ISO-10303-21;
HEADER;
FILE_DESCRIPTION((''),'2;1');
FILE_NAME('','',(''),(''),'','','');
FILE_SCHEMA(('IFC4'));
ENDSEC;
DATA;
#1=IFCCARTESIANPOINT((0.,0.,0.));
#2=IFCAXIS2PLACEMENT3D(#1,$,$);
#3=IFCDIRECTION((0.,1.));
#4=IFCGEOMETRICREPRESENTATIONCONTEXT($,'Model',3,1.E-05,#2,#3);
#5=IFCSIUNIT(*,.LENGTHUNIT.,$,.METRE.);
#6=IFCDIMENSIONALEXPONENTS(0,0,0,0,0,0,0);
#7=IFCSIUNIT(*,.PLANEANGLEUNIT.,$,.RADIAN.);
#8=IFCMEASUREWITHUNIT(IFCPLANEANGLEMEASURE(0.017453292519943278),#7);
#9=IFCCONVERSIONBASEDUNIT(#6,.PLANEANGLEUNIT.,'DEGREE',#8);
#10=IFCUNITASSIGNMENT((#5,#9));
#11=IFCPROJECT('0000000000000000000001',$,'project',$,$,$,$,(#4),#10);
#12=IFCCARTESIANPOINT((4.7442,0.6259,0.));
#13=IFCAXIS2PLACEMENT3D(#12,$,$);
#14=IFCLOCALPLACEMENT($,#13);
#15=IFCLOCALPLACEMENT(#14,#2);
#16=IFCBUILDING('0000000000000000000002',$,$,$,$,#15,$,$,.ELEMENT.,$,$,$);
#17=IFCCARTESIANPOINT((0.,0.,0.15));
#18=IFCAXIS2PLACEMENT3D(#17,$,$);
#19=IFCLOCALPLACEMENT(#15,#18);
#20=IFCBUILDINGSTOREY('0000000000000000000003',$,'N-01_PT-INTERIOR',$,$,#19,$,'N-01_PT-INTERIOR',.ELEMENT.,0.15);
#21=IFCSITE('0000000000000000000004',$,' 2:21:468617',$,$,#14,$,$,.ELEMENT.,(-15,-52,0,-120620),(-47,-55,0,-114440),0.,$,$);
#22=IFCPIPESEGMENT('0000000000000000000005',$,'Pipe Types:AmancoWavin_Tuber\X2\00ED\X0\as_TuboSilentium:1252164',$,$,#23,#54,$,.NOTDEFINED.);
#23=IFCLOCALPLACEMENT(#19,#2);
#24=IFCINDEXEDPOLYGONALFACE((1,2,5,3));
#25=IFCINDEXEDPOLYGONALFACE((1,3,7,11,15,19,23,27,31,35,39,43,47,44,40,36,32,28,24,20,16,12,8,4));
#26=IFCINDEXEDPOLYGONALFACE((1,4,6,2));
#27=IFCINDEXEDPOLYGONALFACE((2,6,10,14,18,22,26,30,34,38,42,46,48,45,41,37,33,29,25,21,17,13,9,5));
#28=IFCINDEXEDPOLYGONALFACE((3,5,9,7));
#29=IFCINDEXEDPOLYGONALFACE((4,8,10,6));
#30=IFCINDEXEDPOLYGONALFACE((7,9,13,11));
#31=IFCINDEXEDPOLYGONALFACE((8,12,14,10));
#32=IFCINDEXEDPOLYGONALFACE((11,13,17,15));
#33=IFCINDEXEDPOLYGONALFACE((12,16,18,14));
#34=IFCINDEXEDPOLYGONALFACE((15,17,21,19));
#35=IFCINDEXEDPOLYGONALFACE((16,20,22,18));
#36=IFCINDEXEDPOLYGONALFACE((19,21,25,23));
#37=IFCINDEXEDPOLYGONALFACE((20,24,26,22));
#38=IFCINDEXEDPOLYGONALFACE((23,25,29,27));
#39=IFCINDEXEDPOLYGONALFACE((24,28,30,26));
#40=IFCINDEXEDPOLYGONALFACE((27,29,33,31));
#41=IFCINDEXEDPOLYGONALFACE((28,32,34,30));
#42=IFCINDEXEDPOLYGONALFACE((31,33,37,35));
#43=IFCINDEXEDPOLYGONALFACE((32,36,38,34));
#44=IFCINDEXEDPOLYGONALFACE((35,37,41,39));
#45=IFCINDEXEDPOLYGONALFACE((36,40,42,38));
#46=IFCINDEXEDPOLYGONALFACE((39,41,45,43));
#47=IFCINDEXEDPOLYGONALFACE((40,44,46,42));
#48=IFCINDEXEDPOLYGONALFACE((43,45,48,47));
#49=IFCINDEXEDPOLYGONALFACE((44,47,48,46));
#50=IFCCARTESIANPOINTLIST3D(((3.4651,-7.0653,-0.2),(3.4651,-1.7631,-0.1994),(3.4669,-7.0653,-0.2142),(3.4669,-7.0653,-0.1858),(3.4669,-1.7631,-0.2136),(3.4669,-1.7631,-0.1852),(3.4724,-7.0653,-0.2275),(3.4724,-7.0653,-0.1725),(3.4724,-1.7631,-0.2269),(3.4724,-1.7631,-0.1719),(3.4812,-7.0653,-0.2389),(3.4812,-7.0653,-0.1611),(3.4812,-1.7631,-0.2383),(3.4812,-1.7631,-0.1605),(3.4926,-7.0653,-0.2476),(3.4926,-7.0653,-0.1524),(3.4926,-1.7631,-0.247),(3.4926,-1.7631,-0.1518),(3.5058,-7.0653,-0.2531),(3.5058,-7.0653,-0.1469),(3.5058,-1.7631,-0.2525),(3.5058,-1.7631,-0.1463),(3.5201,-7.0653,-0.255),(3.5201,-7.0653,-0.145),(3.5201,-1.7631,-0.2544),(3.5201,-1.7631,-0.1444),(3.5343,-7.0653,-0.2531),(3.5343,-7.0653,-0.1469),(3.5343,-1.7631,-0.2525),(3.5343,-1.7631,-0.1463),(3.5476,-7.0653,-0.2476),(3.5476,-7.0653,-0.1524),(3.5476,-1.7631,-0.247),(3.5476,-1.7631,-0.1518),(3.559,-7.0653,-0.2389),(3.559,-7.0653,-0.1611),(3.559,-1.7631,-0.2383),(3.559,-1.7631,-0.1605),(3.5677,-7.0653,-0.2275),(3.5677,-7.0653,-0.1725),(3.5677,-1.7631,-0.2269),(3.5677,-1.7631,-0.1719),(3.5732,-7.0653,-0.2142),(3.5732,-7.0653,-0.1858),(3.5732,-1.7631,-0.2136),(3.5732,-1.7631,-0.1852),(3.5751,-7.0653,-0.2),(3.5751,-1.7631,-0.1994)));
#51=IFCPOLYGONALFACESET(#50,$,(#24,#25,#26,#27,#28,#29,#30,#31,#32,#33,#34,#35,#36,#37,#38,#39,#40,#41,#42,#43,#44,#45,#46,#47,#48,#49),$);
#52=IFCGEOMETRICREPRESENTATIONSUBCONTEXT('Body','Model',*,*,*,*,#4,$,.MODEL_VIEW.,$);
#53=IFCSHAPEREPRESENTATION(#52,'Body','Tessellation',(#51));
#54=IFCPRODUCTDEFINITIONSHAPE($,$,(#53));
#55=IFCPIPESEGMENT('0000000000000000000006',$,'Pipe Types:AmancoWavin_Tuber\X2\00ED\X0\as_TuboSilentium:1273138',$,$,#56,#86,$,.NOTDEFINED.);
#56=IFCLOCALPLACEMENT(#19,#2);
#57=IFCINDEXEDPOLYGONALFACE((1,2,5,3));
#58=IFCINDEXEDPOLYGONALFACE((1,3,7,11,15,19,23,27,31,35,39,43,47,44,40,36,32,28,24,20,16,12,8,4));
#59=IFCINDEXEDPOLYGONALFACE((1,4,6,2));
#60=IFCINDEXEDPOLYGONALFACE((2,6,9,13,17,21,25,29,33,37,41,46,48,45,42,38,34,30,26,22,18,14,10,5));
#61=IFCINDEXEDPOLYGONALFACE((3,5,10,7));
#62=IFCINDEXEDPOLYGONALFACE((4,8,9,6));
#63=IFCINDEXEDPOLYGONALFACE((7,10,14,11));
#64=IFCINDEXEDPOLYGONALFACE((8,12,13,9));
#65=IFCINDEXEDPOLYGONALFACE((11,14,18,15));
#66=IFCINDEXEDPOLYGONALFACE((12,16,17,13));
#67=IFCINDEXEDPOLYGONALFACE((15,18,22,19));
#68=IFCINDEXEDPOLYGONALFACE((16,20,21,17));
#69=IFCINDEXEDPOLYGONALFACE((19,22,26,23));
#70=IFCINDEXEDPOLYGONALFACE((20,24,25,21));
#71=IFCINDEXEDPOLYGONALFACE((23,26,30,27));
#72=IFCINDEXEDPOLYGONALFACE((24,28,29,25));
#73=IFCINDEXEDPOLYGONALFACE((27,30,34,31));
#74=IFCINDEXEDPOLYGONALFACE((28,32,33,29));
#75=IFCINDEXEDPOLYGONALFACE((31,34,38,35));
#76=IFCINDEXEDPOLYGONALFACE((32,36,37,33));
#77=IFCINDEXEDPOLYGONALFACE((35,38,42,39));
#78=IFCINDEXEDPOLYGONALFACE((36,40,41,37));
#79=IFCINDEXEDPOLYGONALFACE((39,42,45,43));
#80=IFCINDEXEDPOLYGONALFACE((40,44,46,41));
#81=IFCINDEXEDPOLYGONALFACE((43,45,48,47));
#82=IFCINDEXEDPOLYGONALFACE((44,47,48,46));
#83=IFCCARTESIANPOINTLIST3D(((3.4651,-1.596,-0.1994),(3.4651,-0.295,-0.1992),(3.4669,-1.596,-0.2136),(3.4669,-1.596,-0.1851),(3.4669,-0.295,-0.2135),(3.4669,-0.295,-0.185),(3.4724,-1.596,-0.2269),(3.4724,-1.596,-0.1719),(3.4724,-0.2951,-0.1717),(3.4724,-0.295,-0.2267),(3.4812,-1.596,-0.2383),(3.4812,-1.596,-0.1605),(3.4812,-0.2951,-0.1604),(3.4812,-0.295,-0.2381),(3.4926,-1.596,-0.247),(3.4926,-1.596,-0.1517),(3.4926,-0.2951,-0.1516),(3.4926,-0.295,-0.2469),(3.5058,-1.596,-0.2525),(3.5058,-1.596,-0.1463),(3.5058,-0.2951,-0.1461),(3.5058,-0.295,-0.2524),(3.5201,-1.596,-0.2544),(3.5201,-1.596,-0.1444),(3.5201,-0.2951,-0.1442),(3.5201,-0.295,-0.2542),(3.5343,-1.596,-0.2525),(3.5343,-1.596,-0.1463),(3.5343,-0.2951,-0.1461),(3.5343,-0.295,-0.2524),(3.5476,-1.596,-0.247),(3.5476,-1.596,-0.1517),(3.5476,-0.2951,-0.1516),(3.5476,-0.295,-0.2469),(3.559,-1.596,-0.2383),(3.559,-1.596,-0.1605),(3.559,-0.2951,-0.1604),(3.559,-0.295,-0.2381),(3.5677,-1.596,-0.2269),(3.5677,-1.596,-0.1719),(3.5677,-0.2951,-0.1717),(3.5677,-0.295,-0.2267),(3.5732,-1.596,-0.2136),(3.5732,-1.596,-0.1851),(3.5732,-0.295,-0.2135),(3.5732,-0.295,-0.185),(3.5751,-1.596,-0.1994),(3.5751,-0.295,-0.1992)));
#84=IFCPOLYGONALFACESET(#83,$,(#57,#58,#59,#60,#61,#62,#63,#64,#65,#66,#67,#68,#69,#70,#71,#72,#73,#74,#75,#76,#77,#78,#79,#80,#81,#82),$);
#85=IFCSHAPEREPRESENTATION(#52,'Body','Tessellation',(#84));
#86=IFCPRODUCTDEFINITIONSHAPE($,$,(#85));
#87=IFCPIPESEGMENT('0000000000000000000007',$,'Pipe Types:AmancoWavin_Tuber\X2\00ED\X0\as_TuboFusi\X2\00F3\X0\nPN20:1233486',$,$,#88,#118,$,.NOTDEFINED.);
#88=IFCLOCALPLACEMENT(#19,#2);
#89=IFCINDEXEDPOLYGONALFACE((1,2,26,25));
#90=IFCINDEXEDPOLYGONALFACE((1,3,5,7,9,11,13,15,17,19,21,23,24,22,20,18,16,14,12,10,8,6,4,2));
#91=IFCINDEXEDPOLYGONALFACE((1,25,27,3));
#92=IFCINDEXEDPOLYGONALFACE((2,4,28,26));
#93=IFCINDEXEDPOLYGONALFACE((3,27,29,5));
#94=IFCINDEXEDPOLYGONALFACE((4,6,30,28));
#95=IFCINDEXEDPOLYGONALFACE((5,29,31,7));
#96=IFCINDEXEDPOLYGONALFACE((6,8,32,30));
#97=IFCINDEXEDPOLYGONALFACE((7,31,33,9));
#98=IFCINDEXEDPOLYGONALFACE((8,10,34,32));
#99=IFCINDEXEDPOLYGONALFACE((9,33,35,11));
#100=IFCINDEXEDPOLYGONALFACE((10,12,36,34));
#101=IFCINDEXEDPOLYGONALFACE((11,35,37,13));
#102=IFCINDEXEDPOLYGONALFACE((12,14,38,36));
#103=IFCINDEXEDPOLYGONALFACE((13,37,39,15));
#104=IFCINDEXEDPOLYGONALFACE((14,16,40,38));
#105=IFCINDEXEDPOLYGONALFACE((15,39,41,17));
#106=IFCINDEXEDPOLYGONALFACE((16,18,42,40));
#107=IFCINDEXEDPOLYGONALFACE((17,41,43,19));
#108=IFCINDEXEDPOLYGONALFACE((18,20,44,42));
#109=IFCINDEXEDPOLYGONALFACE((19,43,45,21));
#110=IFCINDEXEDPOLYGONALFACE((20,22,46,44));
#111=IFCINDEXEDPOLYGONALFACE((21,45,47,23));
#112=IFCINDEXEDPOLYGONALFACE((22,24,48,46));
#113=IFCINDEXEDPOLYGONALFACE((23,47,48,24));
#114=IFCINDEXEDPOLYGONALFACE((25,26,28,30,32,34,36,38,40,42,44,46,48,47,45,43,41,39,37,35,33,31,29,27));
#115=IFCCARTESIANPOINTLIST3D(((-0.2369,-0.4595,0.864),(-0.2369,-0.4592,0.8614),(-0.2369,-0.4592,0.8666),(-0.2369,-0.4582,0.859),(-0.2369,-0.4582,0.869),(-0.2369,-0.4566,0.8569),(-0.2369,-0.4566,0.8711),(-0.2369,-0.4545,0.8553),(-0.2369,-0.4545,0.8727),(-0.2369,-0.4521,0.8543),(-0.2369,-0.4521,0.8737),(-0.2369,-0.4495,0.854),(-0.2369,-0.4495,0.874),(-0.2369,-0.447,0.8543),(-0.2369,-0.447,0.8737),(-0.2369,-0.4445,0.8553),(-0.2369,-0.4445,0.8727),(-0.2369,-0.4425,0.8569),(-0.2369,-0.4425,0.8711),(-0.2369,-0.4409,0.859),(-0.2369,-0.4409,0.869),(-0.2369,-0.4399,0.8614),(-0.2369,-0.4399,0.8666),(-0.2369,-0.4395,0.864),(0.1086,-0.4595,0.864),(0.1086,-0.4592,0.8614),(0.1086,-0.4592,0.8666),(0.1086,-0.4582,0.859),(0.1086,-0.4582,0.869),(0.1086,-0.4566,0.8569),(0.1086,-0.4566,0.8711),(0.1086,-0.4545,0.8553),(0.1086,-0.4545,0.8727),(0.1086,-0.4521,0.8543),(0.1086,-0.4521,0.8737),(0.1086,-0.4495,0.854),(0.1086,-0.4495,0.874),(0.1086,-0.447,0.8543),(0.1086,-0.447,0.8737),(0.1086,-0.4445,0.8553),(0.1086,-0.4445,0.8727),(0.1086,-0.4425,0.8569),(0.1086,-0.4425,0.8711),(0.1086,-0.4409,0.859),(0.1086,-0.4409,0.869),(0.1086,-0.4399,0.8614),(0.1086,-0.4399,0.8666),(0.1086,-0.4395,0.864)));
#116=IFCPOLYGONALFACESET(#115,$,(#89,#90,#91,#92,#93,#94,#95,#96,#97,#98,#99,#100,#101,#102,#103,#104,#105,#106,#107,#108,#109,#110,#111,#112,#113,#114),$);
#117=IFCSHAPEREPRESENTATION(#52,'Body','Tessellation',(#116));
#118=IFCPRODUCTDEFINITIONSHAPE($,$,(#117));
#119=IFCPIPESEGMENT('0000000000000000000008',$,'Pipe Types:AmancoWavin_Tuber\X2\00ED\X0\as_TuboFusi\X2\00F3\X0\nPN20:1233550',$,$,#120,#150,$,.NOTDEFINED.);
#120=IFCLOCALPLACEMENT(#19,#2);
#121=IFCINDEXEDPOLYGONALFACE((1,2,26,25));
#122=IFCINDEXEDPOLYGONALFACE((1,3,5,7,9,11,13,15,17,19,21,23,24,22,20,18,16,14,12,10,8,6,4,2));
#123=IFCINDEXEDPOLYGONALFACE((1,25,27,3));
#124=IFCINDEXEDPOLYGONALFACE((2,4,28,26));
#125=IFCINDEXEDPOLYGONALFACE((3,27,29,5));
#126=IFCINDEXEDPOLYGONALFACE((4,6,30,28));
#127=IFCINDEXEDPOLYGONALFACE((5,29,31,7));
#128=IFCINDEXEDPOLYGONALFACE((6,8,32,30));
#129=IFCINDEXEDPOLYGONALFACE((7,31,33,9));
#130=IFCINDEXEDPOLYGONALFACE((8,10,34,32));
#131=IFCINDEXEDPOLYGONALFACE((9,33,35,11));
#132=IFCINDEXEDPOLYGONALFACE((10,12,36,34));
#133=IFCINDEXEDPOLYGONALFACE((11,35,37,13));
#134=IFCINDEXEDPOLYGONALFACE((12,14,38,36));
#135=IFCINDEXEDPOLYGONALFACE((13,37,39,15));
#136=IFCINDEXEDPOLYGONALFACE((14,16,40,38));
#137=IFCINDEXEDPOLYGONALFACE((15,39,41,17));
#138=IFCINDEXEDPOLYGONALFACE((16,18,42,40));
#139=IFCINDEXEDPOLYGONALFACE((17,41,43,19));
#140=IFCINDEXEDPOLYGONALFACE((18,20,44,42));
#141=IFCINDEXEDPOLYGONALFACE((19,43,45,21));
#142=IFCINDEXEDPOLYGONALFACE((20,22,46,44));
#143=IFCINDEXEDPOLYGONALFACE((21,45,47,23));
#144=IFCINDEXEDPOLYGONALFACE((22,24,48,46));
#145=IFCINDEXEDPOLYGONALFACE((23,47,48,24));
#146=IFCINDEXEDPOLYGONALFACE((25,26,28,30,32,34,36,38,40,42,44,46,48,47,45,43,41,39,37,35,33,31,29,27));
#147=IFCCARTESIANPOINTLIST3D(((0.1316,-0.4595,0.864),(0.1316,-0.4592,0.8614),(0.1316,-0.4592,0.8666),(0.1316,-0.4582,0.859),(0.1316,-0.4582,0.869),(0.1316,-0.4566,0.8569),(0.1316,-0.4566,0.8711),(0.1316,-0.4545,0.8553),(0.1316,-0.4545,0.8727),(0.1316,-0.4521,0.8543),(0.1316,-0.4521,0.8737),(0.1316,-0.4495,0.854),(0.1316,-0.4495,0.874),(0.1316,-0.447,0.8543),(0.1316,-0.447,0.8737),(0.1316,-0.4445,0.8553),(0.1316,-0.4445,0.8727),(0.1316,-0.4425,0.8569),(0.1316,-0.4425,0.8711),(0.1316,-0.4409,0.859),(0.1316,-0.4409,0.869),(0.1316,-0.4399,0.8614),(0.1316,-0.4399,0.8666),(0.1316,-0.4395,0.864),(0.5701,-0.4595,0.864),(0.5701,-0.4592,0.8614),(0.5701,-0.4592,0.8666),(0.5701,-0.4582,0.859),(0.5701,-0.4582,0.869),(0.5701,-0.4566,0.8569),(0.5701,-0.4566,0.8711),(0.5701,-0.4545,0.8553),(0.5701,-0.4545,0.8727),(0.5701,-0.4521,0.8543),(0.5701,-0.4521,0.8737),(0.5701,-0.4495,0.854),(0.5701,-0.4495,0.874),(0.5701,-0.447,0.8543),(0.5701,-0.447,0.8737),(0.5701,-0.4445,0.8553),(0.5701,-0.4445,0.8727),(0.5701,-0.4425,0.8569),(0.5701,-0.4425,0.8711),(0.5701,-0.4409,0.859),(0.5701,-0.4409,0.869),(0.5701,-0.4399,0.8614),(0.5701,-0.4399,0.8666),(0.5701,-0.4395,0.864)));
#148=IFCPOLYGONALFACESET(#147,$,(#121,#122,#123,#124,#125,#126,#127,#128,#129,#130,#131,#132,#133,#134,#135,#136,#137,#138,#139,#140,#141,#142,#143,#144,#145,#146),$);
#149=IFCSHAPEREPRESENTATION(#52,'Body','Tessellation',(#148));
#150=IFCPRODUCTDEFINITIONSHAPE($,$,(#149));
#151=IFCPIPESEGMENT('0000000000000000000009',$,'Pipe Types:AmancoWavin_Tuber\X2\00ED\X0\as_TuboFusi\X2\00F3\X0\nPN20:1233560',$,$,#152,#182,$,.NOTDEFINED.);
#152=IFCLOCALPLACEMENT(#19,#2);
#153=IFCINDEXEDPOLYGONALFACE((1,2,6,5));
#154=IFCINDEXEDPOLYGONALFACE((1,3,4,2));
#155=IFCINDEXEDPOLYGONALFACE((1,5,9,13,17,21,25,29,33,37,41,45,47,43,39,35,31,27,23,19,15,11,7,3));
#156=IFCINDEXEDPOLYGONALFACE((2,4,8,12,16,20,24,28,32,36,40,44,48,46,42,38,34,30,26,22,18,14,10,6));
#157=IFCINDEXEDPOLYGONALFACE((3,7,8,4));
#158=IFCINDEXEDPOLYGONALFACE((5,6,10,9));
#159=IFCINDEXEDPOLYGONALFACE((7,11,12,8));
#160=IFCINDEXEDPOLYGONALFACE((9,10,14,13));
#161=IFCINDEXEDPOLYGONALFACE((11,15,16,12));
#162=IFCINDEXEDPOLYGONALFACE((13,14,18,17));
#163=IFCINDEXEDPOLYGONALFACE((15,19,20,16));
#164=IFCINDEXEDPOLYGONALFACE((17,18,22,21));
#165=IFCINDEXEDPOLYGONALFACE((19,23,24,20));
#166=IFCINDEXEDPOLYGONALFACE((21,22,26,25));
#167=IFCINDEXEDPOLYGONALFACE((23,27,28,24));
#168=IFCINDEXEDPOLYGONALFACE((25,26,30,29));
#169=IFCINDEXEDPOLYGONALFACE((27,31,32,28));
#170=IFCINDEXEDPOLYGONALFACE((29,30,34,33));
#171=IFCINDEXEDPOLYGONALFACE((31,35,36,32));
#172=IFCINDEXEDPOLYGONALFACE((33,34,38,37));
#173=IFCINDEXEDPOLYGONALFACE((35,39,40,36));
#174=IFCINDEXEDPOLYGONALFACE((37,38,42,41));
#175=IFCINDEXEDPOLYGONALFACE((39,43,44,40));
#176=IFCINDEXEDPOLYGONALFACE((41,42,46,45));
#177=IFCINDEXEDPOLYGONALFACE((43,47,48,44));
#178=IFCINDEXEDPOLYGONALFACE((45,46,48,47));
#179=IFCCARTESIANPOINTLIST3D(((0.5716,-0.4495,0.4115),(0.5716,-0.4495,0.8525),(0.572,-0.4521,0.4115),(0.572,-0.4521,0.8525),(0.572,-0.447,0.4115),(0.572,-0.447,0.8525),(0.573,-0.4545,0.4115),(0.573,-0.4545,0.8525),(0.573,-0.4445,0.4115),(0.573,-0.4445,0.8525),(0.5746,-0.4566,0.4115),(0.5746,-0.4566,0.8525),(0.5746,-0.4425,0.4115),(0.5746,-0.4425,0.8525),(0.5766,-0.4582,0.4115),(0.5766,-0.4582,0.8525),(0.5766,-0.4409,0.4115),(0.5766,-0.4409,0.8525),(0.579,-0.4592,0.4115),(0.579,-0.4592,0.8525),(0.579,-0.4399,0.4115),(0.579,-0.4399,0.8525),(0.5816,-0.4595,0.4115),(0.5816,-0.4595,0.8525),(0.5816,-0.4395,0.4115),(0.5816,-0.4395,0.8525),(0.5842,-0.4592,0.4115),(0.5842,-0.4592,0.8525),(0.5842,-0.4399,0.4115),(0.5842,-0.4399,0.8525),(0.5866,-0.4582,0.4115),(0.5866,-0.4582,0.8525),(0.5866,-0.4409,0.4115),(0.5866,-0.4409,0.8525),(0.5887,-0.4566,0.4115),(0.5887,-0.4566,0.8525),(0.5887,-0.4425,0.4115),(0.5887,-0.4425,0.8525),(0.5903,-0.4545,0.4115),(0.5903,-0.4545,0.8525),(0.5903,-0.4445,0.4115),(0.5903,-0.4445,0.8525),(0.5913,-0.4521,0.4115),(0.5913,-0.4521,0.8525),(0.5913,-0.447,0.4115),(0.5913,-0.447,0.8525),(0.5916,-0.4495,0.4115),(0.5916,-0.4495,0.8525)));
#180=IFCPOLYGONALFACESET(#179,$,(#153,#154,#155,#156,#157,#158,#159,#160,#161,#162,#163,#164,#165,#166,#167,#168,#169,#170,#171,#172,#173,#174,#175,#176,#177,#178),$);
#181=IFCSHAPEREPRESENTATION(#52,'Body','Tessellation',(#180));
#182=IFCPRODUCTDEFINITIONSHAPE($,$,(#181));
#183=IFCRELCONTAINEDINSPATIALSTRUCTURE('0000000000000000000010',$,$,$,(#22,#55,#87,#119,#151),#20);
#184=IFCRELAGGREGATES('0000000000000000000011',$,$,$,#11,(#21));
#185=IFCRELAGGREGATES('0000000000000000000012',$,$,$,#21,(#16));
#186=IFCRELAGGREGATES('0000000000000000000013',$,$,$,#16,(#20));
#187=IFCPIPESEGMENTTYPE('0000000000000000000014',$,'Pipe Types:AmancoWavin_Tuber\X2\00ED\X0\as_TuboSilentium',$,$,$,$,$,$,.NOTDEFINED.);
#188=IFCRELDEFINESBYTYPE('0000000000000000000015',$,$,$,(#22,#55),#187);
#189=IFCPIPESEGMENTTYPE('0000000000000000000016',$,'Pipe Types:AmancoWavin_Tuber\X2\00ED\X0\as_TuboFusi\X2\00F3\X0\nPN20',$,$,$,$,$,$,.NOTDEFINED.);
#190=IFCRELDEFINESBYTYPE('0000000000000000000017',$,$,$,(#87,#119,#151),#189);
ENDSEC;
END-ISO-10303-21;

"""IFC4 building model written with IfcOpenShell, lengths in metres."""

from ifc_helpers import new_model, entity, si_unit, converted_unit, direction, frame, origin, place, context, subcontext, project, spatial, arc, indexed_curve, outline, extrude, type_object, element, save


model = new_model("IFC4")

# Units and contexts
model_context = context("Model", 3, precision=1e-05, world=origin(), true_north=direction((0.0, 1.0)))
body_context = subcontext(model_context, "Body", "Model", "MODEL_VIEW")
ifc_project = project(units=[si_unit("LENGTHUNIT", "METRE"), converted_unit("PLANEANGLEUNIT", "DEGREE", entity("IfcPlaneAngleMeasure", 0.017453292519943278), si_unit("PLANEANGLEUNIT", "RADIAN"), dimensions=[0, 0, 0, 0, 0, 0, 0])], contexts=[model_context])

# Site, building, storey
site_placement = place(None, frame((4.7442, 0.6259, 0.0)))
site = spatial("IfcSite", under=ifc_project, at=site_placement, Name=" 2:21:468617", CompositionType="ELEMENT", RefLatitude=(-15, -52, 0, -120620), RefLongitude=(-47, -55, 0, -114440), RefElevation=0.0)
building_placement = place(site_placement, origin())
building = spatial("IfcBuilding", under=site, at=building_placement, CompositionType="ELEMENT")
storey_placement = place(building_placement, frame((0.0, 0.0, 0.15)))
storey = spatial("IfcBuildingStorey", under=building, at=storey_placement, Name="N-01_PT-INTERIOR", LongName="N-01_PT-INTERIOR", CompositionType="ELEMENT", Elevation=0.15)

# Pipe segments
pipe_segment_type_1 = type_object("IfcPipeSegmentType", Name="Pipe Types:AmancoWavin_Tuberías_TuboSilentium", PredefinedType="NOTDEFINED")
pipe_segment_1_placement = place(storey_placement, origin())
element("IfcPipeSegment", 1, at=pipe_segment_1_placement, inside=storey, type_object=pipe_segment_type_1, Name="Pipe Types:AmancoWavin_Tuberías_TuboSilentium:1252164", PredefinedType="NOTDEFINED", context=body_context, shape_type="SweptSolid", body=[
    extrude(outline(indexed_curve([(0.055, 0.0), (0.0389, 0.0389), (0.0, 0.055), (-0.0389, 0.0389), (-0.055, 0.0), (-0.0389, -0.0389), (0.0, -0.055), (0.0389, -0.0389)], segments=[arc(1, 2, 3), arc(3, 4, 5), arc(5, 6, 7), arc(7, 8, 1)], self_intersect=False)), frame((3.5201, -7.0653, -0.2), z_axis=(0.0, 1.0, 0.000114), x_axis=(1.0, 0.0, 0.0)), (0.0, 0.0, 1.0), 5.3022),
])
pipe_segment_2_placement = place(storey_placement, origin())
element("IfcPipeSegment", 2, at=pipe_segment_2_placement, inside=storey, type_object=pipe_segment_type_1, Name="Pipe Types:AmancoWavin_Tuberías_TuboSilentium:1273138", PredefinedType="NOTDEFINED", context=body_context, shape_type="SweptSolid", body=[
    extrude(outline(indexed_curve([(0.055, 0.0), (0.0389, 0.0389), (0.0, 0.055), (-0.0389, 0.0389), (-0.055, 0.0), (-0.0389, -0.0389), (0.0, -0.055), (0.0389, -0.0389)], segments=[arc(1, 2, 3), arc(3, 4, 5), arc(5, 6, 7), arc(7, 8, 1)], self_intersect=False)), frame((3.5201, -1.596, -0.1994), z_axis=(0.0, 1.0, 0.000105), x_axis=(-1.0, 0.0, 0.0)), (0.0, 0.0, 1.0), 1.3009),
])
pipe_segment_type_2 = type_object("IfcPipeSegmentType", Name="Pipe Types:AmancoWavin_Tuberías_TuboFusiónPN20", PredefinedType="NOTDEFINED")
pipe_segment_3_placement = place(storey_placement, origin())
element("IfcPipeSegment", 3, at=pipe_segment_3_placement, inside=storey, type_object=pipe_segment_type_2, Name="Pipe Types:AmancoWavin_Tuberías_TuboFusiónPN20:1233486", PredefinedType="NOTDEFINED", context=body_context, shape_type="SweptSolid", body=[
    extrude(outline(indexed_curve([(0.01, 0.0), (0.0071, 0.0071), (0.0, 0.01), (-0.0071, 0.0071), (-0.01, 0.0), (-0.0071, -0.0071), (0.0, -0.01), (0.0071, -0.0071)], segments=[arc(1, 2, 3), arc(3, 4, 5), arc(5, 6, 7), arc(7, 8, 1)], self_intersect=False)), frame((-0.2369, -0.4495, 0.864), z_axis=(1.0, 0.0, 0.0), x_axis=(0.0, 1.0, 0.0)), (0.0, 0.0, 1.0), 0.3455),
])
pipe_segment_4_placement = place(storey_placement, origin())
element("IfcPipeSegment", 4, at=pipe_segment_4_placement, inside=storey, type_object=pipe_segment_type_2, Name="Pipe Types:AmancoWavin_Tuberías_TuboFusiónPN20:1233550", PredefinedType="NOTDEFINED", context=body_context, shape_type="SweptSolid", body=[
    extrude(outline(indexed_curve([(0.01, 0.0), (0.0071, 0.0071), (0.0, 0.01), (-0.0071, 0.0071), (-0.01, 0.0), (-0.0071, -0.0071), (0.0, -0.01), (0.0071, -0.0071)], segments=[arc(1, 2, 3), arc(3, 4, 5), arc(5, 6, 7), arc(7, 8, 1)], self_intersect=False)), frame((0.1316, -0.4495, 0.864), z_axis=(1.0, 0.0, 0.0), x_axis=(0.0, -1.0, 0.0)), (0.0, 0.0, 1.0), 0.4385),
])
pipe_segment_5_placement = place(storey_placement, origin())
element("IfcPipeSegment", 5, at=pipe_segment_5_placement, inside=storey, type_object=pipe_segment_type_2, Name="Pipe Types:AmancoWavin_Tuberías_TuboFusiónPN20:1233560", PredefinedType="NOTDEFINED", context=body_context, shape_type="SweptSolid", body=[
    extrude(outline(indexed_curve([(0.01, 0.0), (0.0071, 0.0071), (0.0, 0.01), (-0.0071, 0.0071), (-0.01, 0.0), (-0.0071, -0.0071), (0.0, -0.01), (0.0071, -0.0071)], segments=[arc(1, 2, 3), arc(3, 4, 5), arc(5, 6, 7), arc(7, 8, 1)], self_intersect=False)), frame((0.5816, -0.4495, 0.4115)), (0.0, 0.0, 1.0), 0.441),
])

save(model, "model.ifc")
